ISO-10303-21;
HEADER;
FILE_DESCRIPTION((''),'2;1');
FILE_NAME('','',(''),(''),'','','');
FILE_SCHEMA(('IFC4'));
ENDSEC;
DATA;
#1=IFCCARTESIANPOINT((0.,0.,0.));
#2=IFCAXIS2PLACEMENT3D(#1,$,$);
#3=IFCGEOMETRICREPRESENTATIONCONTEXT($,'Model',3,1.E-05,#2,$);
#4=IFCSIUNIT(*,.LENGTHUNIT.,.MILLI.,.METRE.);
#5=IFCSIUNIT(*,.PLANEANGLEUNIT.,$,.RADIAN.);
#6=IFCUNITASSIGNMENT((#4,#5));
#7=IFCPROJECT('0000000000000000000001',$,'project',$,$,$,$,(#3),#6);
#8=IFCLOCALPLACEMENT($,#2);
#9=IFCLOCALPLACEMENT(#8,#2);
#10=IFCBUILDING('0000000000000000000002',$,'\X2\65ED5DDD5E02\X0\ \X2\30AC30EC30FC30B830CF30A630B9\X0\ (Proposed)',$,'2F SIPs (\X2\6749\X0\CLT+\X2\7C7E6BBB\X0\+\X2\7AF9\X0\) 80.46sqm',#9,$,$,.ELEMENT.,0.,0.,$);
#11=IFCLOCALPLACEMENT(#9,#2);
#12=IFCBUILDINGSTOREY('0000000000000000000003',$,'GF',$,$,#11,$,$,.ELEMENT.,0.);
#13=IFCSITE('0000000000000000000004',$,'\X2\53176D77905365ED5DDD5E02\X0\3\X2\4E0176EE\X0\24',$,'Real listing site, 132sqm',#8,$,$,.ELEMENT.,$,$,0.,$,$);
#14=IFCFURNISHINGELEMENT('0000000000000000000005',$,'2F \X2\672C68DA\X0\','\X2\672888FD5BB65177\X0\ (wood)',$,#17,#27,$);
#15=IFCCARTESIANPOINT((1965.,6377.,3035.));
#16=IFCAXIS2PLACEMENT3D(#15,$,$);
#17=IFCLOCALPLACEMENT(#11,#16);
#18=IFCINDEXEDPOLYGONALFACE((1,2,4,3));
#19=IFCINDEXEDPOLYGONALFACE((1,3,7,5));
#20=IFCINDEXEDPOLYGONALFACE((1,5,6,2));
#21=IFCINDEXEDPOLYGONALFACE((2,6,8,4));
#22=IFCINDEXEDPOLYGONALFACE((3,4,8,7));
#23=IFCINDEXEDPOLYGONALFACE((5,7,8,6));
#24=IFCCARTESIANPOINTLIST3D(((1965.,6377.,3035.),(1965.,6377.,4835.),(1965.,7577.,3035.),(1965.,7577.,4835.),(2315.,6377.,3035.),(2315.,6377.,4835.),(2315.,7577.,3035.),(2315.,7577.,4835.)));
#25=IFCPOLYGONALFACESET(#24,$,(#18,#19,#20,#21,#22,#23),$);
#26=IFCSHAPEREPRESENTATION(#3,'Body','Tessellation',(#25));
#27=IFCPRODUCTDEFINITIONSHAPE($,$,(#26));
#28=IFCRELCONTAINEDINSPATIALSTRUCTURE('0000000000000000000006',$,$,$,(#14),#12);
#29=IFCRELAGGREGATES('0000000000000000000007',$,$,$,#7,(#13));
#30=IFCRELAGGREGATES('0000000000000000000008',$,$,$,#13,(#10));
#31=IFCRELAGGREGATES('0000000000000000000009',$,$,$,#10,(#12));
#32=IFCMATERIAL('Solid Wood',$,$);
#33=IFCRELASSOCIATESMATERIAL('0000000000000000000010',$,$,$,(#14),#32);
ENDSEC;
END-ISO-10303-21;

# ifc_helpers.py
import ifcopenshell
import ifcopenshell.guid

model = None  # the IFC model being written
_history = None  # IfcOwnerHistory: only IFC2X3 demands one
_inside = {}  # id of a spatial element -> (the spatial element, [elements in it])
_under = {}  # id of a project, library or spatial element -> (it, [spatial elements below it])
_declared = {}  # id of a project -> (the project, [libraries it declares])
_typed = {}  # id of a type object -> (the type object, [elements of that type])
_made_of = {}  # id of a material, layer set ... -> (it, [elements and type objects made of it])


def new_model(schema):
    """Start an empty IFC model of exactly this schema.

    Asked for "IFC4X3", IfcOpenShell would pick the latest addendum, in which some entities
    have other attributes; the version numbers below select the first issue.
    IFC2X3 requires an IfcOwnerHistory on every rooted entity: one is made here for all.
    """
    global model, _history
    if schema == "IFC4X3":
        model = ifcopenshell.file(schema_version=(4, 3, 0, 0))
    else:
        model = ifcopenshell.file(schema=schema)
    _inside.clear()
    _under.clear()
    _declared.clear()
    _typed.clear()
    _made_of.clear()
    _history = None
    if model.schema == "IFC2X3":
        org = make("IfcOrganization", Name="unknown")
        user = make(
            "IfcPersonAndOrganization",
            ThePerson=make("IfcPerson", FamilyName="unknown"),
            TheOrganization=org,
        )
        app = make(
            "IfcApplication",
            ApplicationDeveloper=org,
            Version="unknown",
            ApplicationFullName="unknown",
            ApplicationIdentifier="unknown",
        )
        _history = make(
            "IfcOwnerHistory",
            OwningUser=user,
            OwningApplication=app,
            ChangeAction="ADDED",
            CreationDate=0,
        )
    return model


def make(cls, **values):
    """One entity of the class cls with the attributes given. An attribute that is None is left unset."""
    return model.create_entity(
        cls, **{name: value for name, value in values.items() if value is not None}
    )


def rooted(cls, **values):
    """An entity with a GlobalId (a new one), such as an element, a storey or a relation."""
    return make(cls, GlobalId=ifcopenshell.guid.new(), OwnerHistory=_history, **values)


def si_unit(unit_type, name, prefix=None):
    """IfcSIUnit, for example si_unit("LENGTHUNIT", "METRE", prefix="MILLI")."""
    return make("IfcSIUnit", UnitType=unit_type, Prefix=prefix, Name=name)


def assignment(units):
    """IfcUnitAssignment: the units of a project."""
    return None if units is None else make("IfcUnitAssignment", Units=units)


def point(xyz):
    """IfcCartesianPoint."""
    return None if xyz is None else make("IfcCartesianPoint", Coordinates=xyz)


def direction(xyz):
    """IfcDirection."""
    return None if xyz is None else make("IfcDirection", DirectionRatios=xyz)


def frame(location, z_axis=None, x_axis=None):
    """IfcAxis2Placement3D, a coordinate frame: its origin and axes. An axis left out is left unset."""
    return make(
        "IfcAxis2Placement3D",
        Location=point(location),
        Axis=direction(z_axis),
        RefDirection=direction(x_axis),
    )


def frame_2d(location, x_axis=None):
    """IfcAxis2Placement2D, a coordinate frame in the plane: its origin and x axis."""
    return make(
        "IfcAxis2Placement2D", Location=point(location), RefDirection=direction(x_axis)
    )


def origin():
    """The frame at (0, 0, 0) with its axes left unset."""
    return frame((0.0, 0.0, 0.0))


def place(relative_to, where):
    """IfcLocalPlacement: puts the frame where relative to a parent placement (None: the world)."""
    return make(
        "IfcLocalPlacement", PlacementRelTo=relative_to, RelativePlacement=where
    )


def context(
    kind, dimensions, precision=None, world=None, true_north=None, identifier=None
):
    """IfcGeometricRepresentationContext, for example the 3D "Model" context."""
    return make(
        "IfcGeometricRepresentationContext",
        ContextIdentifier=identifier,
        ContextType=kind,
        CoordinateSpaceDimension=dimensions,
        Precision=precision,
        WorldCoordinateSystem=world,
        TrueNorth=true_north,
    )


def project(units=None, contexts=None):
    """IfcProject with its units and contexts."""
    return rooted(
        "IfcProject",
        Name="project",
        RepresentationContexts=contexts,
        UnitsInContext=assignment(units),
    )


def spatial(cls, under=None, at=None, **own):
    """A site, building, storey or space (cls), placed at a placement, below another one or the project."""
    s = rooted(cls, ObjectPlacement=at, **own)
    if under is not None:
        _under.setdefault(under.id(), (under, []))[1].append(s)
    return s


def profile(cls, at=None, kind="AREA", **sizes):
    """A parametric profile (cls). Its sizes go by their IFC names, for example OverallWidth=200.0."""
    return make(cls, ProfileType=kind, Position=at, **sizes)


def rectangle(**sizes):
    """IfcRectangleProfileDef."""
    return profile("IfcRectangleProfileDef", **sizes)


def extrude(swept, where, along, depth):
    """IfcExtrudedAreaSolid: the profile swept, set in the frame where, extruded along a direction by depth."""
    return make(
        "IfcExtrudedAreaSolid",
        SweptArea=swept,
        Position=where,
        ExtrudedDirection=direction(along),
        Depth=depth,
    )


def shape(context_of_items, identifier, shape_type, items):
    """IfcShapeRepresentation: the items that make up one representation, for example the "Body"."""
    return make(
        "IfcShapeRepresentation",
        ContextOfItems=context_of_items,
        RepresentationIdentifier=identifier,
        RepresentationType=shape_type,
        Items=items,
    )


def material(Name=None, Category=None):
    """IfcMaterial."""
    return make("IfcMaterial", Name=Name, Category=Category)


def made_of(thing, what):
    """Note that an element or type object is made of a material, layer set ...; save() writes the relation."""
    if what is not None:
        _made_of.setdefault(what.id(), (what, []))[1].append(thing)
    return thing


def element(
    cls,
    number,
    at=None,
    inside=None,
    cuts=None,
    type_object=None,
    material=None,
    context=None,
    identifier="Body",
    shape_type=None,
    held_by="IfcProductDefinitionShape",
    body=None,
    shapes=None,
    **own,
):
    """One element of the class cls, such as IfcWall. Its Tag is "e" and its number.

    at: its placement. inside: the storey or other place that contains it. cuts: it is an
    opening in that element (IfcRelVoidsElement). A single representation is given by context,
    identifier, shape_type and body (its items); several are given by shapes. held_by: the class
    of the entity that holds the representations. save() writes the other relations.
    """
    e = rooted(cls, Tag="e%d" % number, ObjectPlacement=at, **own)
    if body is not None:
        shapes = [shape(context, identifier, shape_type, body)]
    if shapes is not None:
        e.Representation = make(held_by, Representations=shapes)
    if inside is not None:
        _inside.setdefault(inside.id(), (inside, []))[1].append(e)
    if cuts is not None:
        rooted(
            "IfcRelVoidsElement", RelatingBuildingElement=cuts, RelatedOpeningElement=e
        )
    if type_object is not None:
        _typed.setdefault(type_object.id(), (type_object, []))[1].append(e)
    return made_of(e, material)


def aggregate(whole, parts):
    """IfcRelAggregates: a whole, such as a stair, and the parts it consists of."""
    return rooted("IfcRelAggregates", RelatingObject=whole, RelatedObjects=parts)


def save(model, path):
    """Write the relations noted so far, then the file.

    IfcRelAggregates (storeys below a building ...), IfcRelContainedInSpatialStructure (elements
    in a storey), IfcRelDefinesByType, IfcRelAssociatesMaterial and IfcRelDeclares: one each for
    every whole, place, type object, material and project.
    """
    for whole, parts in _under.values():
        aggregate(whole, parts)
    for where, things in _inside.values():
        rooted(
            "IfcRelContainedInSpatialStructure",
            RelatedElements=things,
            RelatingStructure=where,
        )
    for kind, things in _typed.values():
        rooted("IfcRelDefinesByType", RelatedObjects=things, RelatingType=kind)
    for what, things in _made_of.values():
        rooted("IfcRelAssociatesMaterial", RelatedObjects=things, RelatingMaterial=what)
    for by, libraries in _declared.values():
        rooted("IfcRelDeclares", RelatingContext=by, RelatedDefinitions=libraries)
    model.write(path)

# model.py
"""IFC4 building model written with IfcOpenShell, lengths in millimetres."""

from ifc_helpers import new_model, si_unit, frame, frame_2d, origin, place, context, project, spatial, rectangle, extrude, material, element, save


model = new_model("IFC4")

# Units and contexts
model_context = context("Model", 3, precision=1e-05, world=origin())
ifc_project = project(units=[si_unit("LENGTHUNIT", "METRE", prefix="MILLI"), si_unit("PLANEANGLEUNIT", "RADIAN")], contexts=[model_context])

# Site, building, storey
site_placement = place(None, origin())
site = spatial("IfcSite", under=ifc_project, at=site_placement, Name="北海道旭川市3丁目24", ObjectType="Real listing site, 132sqm", CompositionType="ELEMENT", RefElevation=0.0)
building_placement = place(site_placement, origin())
building = spatial("IfcBuilding", under=site, at=building_placement, Name="旭川市 ガレージハウス (Proposed)", ObjectType="2F SIPs (杉CLT+籾殻+竹) 80.46sqm", CompositionType="ELEMENT", ElevationOfRefHeight=0.0, ElevationOfTerrain=0.0)
storey_placement = place(building_placement, origin())
storey = spatial("IfcBuildingStorey", under=building, at=storey_placement, Name="GF", CompositionType="ELEMENT", Elevation=0.0)

# Shared definitions
ifc_material_1 = material(Name="Solid Wood")

# Furnishing element
furnishing_placement = place(storey_placement, frame((1965.0, 6377.0, 3035.0)))
element("IfcFurnishingElement", 1, at=furnishing_placement, inside=storey, material=ifc_material_1, Name="2F 本棚", Description="木製家具 (wood)", context=model_context, shape_type="SweptSolid", body=[
    extrude(rectangle(XDim=350.0, YDim=1200.0, at=frame_2d((175.0, 600.0))), frame((1965.0, 6377.0, 3035.0)), (0.0, 0.0, 1.0), 1800.0),
])

save(model, "model.ifc")
